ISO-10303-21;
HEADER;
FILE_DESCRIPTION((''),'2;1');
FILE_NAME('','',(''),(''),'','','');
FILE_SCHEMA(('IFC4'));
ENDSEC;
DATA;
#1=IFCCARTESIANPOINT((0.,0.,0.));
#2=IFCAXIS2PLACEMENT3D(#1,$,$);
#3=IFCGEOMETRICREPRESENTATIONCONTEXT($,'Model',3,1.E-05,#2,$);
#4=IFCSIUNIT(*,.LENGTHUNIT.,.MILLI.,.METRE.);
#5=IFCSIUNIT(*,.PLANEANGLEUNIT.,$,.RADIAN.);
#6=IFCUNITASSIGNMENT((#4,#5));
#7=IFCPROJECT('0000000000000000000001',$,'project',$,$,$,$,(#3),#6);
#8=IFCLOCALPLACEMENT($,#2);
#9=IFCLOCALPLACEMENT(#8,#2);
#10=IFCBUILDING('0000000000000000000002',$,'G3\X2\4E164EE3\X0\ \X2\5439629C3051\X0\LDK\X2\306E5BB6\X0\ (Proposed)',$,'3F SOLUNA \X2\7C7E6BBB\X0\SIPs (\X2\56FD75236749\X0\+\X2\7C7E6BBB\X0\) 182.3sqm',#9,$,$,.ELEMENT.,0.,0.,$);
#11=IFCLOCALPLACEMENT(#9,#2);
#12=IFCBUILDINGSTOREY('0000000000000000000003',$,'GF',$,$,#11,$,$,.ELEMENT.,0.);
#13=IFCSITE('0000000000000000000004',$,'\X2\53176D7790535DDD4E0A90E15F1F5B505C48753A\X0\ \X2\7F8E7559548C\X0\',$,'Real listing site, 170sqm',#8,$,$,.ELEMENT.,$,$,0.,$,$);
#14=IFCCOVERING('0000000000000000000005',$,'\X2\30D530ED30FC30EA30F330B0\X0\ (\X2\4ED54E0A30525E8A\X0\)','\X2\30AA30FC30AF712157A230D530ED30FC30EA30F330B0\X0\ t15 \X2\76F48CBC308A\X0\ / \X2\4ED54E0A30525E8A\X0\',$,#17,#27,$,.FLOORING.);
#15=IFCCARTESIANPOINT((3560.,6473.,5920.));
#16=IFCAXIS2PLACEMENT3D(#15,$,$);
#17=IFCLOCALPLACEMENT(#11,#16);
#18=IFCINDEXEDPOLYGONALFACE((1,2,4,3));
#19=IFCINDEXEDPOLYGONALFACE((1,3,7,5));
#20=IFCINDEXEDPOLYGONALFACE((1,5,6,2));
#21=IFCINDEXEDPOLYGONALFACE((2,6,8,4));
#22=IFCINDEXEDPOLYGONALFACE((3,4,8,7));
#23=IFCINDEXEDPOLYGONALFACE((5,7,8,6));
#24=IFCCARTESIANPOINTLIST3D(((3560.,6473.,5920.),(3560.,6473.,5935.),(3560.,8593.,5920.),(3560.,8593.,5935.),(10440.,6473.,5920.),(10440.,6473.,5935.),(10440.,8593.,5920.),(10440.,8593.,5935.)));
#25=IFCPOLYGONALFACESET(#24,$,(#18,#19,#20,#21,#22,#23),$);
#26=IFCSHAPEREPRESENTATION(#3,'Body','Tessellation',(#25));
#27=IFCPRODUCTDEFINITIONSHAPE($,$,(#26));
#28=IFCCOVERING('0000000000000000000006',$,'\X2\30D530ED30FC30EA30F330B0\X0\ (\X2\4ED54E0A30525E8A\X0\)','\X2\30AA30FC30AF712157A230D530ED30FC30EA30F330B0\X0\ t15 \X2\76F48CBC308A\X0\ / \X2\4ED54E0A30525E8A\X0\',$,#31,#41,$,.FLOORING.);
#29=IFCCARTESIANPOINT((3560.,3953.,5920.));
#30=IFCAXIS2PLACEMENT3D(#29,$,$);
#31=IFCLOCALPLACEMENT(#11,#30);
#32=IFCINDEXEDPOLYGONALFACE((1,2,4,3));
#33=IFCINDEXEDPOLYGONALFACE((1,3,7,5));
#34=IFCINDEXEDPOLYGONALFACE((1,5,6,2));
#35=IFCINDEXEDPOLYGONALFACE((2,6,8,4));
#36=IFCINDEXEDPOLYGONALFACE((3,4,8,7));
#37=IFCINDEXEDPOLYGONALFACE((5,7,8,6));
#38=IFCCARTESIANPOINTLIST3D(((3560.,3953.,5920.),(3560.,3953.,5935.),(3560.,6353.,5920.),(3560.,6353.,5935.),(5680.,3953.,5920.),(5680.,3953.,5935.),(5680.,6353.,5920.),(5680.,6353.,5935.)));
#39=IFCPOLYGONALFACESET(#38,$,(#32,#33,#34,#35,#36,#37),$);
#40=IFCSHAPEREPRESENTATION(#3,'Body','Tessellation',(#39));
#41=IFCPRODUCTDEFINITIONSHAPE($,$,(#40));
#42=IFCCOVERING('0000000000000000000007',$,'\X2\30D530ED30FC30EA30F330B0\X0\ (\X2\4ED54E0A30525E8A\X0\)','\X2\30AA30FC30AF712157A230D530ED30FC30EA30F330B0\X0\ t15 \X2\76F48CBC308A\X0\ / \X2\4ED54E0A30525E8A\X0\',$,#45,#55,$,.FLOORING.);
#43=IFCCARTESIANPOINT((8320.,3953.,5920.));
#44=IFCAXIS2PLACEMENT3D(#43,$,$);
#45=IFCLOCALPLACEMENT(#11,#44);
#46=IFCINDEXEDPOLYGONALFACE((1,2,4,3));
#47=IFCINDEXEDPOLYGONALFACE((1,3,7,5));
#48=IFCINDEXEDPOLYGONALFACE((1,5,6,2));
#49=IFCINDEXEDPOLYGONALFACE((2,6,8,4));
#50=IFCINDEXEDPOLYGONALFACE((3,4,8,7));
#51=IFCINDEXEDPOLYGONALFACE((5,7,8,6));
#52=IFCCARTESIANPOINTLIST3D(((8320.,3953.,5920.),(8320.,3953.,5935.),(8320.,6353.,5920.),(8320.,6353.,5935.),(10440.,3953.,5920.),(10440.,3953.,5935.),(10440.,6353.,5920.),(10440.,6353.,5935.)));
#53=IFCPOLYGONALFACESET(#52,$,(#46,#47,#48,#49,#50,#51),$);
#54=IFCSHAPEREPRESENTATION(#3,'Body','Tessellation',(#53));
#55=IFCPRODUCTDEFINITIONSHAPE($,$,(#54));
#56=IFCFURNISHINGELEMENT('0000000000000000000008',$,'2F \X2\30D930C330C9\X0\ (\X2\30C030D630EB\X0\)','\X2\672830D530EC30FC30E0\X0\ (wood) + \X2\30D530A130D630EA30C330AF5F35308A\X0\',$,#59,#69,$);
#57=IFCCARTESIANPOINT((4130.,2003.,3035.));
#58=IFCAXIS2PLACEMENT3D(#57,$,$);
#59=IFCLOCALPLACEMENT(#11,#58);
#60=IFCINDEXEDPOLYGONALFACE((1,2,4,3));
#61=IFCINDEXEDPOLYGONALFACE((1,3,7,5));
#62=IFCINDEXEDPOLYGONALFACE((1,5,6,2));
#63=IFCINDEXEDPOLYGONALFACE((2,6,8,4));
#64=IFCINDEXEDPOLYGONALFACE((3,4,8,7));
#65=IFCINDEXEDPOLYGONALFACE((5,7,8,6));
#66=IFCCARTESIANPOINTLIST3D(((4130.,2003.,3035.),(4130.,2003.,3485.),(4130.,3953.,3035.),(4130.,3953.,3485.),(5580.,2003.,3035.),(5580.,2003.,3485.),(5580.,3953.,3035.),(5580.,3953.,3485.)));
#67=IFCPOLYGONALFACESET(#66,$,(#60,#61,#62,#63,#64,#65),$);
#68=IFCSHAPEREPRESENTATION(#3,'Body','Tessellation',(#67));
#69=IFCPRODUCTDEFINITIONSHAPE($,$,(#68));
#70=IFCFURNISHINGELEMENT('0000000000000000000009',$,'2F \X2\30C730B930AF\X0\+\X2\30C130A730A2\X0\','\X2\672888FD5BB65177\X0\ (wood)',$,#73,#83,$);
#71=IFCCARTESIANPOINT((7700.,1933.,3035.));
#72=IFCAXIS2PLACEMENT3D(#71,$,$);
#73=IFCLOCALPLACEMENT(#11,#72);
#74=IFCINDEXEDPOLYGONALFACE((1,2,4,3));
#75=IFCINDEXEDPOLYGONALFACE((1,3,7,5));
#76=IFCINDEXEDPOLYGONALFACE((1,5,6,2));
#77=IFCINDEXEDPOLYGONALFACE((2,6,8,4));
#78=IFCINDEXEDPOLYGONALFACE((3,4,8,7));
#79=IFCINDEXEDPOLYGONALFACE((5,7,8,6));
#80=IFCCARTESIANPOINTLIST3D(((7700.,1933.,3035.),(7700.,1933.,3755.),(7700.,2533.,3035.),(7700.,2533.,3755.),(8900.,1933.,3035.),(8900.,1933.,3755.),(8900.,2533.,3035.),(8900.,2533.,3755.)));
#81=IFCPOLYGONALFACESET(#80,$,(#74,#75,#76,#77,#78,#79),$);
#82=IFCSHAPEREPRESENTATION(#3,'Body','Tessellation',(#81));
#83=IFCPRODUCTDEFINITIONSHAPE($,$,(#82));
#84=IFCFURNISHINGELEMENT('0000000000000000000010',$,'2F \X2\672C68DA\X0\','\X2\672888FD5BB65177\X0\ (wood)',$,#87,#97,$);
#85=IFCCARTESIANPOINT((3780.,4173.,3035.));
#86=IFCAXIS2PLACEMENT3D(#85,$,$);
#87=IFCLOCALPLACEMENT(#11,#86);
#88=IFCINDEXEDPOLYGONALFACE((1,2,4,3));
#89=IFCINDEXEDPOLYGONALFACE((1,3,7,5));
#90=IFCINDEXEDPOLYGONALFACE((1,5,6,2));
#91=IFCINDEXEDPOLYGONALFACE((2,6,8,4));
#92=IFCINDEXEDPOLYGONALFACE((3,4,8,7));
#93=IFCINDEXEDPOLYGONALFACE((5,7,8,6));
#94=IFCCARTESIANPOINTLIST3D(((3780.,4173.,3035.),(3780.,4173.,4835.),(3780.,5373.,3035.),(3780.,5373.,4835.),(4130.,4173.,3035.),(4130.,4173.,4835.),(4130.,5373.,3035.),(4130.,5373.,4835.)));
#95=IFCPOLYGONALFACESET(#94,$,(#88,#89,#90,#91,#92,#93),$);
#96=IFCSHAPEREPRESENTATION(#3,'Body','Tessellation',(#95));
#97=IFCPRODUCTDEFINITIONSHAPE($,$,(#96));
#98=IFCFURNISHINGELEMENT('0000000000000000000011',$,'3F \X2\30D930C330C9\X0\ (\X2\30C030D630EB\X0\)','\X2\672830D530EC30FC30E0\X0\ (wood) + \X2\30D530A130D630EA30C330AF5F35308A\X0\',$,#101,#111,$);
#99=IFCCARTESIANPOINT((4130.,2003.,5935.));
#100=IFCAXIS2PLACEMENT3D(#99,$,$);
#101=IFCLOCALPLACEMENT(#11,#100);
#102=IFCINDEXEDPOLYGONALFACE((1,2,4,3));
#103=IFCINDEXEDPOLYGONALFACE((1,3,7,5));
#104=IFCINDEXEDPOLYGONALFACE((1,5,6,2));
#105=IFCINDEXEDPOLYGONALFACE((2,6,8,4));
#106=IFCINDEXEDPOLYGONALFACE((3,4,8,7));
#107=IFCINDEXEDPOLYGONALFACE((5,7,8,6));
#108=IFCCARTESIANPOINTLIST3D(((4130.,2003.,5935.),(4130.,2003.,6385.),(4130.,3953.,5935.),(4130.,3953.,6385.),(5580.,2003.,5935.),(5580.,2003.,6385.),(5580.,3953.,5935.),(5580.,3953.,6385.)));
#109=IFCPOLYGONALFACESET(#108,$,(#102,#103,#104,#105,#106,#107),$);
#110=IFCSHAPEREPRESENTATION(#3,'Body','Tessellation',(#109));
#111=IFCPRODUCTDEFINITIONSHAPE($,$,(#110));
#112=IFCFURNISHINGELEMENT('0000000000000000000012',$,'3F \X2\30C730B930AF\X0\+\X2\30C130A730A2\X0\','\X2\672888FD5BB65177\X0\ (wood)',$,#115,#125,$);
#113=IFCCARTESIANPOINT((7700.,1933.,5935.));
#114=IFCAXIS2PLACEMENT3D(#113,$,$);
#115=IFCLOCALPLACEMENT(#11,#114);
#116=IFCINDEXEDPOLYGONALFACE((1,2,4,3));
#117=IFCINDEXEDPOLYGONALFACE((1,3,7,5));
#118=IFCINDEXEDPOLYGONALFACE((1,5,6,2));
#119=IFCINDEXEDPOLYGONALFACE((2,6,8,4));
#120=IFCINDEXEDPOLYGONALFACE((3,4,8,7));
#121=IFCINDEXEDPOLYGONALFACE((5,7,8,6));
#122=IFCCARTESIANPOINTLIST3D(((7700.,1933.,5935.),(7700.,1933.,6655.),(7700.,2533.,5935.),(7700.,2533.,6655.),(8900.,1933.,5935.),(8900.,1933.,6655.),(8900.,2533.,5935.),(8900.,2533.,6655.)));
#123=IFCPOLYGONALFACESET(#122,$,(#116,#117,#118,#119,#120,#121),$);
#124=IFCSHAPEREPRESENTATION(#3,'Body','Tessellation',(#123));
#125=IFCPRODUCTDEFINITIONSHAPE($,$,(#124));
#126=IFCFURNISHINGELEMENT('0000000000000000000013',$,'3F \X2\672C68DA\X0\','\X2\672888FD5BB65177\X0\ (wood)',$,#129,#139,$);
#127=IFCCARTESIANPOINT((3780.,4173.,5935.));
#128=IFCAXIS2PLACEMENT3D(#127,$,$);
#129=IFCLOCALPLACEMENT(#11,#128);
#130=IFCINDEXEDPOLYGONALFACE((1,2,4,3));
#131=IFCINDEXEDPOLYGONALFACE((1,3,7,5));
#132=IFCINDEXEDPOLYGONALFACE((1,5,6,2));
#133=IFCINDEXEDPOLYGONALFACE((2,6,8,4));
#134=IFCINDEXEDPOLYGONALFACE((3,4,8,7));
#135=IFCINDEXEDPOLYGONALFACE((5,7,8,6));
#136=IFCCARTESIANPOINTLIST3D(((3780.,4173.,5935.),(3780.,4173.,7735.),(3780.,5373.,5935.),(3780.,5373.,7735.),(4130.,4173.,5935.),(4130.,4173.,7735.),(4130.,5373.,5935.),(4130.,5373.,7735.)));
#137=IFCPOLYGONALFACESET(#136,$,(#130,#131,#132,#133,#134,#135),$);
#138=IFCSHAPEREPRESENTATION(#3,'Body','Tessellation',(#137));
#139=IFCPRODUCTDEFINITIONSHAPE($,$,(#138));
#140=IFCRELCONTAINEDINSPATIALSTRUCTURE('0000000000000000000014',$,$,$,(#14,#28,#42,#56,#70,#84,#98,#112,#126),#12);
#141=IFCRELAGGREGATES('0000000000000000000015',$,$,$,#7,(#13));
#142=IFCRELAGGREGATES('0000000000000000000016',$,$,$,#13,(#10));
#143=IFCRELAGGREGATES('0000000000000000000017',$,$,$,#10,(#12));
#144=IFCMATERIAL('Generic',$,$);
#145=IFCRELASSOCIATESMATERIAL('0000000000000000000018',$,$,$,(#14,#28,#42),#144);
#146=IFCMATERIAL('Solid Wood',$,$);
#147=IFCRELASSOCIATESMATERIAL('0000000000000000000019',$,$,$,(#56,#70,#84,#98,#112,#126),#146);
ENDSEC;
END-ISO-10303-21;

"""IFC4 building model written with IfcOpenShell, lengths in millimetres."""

from ifc_helpers import new_model, si_unit, frame, frame_2d, origin, place, context, project, spatial, rectangle, extrude, material, element, save


model = new_model("IFC4")

# Units and contexts
model_context = context("Model", 3, precision=1e-05, world=origin())
ifc_project = project(units=[si_unit("LENGTHUNIT", "METRE", prefix="MILLI"), si_unit("PLANEANGLEUNIT", "RADIAN")], contexts=[model_context])

# Site, building, storey
site_placement = place(None, origin())
site = spatial("IfcSite", under=ifc_project, at=site_placement, Name="北海道川上郡弟子屈町 美留和", ObjectType="Real listing site, 170sqm", CompositionType="ELEMENT", RefElevation=0.0)
building_placement = place(site_placement, origin())
building = spatial("IfcBuilding", under=site, at=building_placement, Name="G3世代 吹抜けLDKの家 (Proposed)", ObjectType="3F SOLUNA 籾殻SIPs (国産杉+籾殻) 182.3sqm", CompositionType="ELEMENT", ElevationOfRefHeight=0.0, ElevationOfTerrain=0.0)
storey_placement = place(building_placement, origin())
storey = spatial("IfcBuildingStorey", under=building, at=storey_placement, Name="GF", CompositionType="ELEMENT", Elevation=0.0)

# Shared definitions
ifc_material_1 = material(Name="Solid Wood")

# Shared definitions
ifc_material_2 = material(Name="Generic")

# Coverings
covering_1_placement = place(storey_placement, frame((3560.0, 6473.0, 5920.0)))
element("IfcCovering", 1, at=covering_1_placement, inside=storey, material=ifc_material_2, Name="フローリング (仕上げ床)", Description="オーク無垢フローリング t15 直貼り / 仕上げ床", PredefinedType="FLOORING", context=model_context, shape_type="SweptSolid", body=[
    extrude(rectangle(XDim=6880.0, YDim=2120.0, at=frame_2d((3440.0, 1060.0))), frame((3560.0, 6473.0, 5920.0)), (0.0, 0.0, 1.0), 15.0),
])
covering_2_placement = place(storey_placement, frame((3560.0, 3953.0, 5920.0)))
element("IfcCovering", 2, at=covering_2_placement, inside=storey, material=ifc_material_2, Name="フローリング (仕上げ床)", Description="オーク無垢フローリング t15 直貼り / 仕上げ床", PredefinedType="FLOORING", context=model_context, shape_type="SweptSolid", body=[
    extrude(rectangle(XDim=2120.0, YDim=2400.0, at=frame_2d((1060.0, 1200.0))), frame((3560.0, 3953.0, 5920.0)), (0.0, 0.0, 1.0), 15.0),
])
covering_3_placement = place(storey_placement, frame((8320.0, 3953.0, 5920.0)))
element("IfcCovering", 3, at=covering_3_placement, inside=storey, material=ifc_material_2, Name="フローリング (仕上げ床)", Description="オーク無垢フローリング t15 直貼り / 仕上げ床", PredefinedType="FLOORING", context=model_context, shape_type="SweptSolid", body=[
    extrude(rectangle(XDim=2120.0, YDim=2400.0, at=frame_2d((1060.0, 1200.0))), frame((8320.0, 3953.0, 5920.0)), (0.0, 0.0, 1.0), 15.0),
])

# Furnishing elements
furnishing_1_placement = place(storey_placement, frame((4130.0, 2003.0, 3035.0)))
element("IfcFurnishingElement", 4, at=furnishing_1_placement, inside=storey, material=ifc_material_1, Name="2F ベッド (ダブル)", Description="木フレーム (wood) + ファブリック張り", context=model_context, shape_type="SweptSolid", body=[
    extrude(rectangle(XDim=1450.0, YDim=1950.0, at=frame_2d((725.0, 975.0))), frame((4130.0, 2003.0, 3035.0)), (0.0, 0.0, 1.0), 450.0),
])
furnishing_2_placement = place(storey_placement, frame((7700.0, 1933.0, 3035.0)))
element("IfcFurnishingElement", 5, at=furnishing_2_placement, inside=storey, material=ifc_material_1, Name="2F デスク+チェア", Description="木製家具 (wood)", context=model_context, shape_type="SweptSolid", body=[
    extrude(rectangle(XDim=1200.0, YDim=600.0, at=frame_2d((600.0, 300.0))), frame((7700.0, 1933.0, 3035.0)), (0.0, 0.0, 1.0), 720.0),
])
furnishing_3_placement = place(storey_placement, frame((3780.0, 4173.0, 3035.0)))
element("IfcFurnishingElement", 6, at=furnishing_3_placement, inside=storey, material=ifc_material_1, Name="2F 本棚", Description="木製家具 (wood)", context=model_context, shape_type="SweptSolid", body=[
    extrude(rectangle(XDim=350.0, YDim=1200.0, at=frame_2d((175.0, 600.0))), frame((3780.0, 4173.0, 3035.0)), (0.0, 0.0, 1.0), 1800.0),
])
furnishing_4_placement = place(storey_placement, frame((4130.0, 2003.0, 5935.0)))
element("IfcFurnishingElement", 7, at=furnishing_4_placement, inside=storey, material=ifc_material_1, Name="3F ベッド (ダブル)", Description="木フレーム (wood) + ファブリック張り", context=model_context, shape_type="SweptSolid", body=[
    extrude(rectangle(XDim=1450.0, YDim=1950.0, at=frame_2d((725.0, 975.0))), frame((4130.0, 2003.0, 5935.0)), (0.0, 0.0, 1.0), 450.0),
])
furnishing_5_placement = place(storey_placement, frame((7700.0, 1933.0, 5935.0)))
element("IfcFurnishingElement", 8, at=furnishing_5_placement, inside=storey, material=ifc_material_1, Name="3F デスク+チェア", Description="木製家具 (wood)", context=model_context, shape_type="SweptSolid", body=[
    extrude(rectangle(XDim=1200.0, YDim=600.0, at=frame_2d((600.0, 300.0))), frame((7700.0, 1933.0, 5935.0)), (0.0, 0.0, 1.0), 720.0),
])
furnishing_6_placement = place(storey_placement, frame((3780.0, 4173.0, 5935.0)))
element("IfcFurnishingElement", 9, at=furnishing_6_placement, inside=storey, material=ifc_material_1, Name="3F 本棚", Description="木製家具 (wood)", context=model_context, shape_type="SweptSolid", body=[
    extrude(rectangle(XDim=350.0, YDim=1200.0, at=frame_2d((175.0, 600.0))), frame((3780.0, 4173.0, 5935.0)), (0.0, 0.0, 1.0), 1800.0),
])

save(model, "model.ifc")
